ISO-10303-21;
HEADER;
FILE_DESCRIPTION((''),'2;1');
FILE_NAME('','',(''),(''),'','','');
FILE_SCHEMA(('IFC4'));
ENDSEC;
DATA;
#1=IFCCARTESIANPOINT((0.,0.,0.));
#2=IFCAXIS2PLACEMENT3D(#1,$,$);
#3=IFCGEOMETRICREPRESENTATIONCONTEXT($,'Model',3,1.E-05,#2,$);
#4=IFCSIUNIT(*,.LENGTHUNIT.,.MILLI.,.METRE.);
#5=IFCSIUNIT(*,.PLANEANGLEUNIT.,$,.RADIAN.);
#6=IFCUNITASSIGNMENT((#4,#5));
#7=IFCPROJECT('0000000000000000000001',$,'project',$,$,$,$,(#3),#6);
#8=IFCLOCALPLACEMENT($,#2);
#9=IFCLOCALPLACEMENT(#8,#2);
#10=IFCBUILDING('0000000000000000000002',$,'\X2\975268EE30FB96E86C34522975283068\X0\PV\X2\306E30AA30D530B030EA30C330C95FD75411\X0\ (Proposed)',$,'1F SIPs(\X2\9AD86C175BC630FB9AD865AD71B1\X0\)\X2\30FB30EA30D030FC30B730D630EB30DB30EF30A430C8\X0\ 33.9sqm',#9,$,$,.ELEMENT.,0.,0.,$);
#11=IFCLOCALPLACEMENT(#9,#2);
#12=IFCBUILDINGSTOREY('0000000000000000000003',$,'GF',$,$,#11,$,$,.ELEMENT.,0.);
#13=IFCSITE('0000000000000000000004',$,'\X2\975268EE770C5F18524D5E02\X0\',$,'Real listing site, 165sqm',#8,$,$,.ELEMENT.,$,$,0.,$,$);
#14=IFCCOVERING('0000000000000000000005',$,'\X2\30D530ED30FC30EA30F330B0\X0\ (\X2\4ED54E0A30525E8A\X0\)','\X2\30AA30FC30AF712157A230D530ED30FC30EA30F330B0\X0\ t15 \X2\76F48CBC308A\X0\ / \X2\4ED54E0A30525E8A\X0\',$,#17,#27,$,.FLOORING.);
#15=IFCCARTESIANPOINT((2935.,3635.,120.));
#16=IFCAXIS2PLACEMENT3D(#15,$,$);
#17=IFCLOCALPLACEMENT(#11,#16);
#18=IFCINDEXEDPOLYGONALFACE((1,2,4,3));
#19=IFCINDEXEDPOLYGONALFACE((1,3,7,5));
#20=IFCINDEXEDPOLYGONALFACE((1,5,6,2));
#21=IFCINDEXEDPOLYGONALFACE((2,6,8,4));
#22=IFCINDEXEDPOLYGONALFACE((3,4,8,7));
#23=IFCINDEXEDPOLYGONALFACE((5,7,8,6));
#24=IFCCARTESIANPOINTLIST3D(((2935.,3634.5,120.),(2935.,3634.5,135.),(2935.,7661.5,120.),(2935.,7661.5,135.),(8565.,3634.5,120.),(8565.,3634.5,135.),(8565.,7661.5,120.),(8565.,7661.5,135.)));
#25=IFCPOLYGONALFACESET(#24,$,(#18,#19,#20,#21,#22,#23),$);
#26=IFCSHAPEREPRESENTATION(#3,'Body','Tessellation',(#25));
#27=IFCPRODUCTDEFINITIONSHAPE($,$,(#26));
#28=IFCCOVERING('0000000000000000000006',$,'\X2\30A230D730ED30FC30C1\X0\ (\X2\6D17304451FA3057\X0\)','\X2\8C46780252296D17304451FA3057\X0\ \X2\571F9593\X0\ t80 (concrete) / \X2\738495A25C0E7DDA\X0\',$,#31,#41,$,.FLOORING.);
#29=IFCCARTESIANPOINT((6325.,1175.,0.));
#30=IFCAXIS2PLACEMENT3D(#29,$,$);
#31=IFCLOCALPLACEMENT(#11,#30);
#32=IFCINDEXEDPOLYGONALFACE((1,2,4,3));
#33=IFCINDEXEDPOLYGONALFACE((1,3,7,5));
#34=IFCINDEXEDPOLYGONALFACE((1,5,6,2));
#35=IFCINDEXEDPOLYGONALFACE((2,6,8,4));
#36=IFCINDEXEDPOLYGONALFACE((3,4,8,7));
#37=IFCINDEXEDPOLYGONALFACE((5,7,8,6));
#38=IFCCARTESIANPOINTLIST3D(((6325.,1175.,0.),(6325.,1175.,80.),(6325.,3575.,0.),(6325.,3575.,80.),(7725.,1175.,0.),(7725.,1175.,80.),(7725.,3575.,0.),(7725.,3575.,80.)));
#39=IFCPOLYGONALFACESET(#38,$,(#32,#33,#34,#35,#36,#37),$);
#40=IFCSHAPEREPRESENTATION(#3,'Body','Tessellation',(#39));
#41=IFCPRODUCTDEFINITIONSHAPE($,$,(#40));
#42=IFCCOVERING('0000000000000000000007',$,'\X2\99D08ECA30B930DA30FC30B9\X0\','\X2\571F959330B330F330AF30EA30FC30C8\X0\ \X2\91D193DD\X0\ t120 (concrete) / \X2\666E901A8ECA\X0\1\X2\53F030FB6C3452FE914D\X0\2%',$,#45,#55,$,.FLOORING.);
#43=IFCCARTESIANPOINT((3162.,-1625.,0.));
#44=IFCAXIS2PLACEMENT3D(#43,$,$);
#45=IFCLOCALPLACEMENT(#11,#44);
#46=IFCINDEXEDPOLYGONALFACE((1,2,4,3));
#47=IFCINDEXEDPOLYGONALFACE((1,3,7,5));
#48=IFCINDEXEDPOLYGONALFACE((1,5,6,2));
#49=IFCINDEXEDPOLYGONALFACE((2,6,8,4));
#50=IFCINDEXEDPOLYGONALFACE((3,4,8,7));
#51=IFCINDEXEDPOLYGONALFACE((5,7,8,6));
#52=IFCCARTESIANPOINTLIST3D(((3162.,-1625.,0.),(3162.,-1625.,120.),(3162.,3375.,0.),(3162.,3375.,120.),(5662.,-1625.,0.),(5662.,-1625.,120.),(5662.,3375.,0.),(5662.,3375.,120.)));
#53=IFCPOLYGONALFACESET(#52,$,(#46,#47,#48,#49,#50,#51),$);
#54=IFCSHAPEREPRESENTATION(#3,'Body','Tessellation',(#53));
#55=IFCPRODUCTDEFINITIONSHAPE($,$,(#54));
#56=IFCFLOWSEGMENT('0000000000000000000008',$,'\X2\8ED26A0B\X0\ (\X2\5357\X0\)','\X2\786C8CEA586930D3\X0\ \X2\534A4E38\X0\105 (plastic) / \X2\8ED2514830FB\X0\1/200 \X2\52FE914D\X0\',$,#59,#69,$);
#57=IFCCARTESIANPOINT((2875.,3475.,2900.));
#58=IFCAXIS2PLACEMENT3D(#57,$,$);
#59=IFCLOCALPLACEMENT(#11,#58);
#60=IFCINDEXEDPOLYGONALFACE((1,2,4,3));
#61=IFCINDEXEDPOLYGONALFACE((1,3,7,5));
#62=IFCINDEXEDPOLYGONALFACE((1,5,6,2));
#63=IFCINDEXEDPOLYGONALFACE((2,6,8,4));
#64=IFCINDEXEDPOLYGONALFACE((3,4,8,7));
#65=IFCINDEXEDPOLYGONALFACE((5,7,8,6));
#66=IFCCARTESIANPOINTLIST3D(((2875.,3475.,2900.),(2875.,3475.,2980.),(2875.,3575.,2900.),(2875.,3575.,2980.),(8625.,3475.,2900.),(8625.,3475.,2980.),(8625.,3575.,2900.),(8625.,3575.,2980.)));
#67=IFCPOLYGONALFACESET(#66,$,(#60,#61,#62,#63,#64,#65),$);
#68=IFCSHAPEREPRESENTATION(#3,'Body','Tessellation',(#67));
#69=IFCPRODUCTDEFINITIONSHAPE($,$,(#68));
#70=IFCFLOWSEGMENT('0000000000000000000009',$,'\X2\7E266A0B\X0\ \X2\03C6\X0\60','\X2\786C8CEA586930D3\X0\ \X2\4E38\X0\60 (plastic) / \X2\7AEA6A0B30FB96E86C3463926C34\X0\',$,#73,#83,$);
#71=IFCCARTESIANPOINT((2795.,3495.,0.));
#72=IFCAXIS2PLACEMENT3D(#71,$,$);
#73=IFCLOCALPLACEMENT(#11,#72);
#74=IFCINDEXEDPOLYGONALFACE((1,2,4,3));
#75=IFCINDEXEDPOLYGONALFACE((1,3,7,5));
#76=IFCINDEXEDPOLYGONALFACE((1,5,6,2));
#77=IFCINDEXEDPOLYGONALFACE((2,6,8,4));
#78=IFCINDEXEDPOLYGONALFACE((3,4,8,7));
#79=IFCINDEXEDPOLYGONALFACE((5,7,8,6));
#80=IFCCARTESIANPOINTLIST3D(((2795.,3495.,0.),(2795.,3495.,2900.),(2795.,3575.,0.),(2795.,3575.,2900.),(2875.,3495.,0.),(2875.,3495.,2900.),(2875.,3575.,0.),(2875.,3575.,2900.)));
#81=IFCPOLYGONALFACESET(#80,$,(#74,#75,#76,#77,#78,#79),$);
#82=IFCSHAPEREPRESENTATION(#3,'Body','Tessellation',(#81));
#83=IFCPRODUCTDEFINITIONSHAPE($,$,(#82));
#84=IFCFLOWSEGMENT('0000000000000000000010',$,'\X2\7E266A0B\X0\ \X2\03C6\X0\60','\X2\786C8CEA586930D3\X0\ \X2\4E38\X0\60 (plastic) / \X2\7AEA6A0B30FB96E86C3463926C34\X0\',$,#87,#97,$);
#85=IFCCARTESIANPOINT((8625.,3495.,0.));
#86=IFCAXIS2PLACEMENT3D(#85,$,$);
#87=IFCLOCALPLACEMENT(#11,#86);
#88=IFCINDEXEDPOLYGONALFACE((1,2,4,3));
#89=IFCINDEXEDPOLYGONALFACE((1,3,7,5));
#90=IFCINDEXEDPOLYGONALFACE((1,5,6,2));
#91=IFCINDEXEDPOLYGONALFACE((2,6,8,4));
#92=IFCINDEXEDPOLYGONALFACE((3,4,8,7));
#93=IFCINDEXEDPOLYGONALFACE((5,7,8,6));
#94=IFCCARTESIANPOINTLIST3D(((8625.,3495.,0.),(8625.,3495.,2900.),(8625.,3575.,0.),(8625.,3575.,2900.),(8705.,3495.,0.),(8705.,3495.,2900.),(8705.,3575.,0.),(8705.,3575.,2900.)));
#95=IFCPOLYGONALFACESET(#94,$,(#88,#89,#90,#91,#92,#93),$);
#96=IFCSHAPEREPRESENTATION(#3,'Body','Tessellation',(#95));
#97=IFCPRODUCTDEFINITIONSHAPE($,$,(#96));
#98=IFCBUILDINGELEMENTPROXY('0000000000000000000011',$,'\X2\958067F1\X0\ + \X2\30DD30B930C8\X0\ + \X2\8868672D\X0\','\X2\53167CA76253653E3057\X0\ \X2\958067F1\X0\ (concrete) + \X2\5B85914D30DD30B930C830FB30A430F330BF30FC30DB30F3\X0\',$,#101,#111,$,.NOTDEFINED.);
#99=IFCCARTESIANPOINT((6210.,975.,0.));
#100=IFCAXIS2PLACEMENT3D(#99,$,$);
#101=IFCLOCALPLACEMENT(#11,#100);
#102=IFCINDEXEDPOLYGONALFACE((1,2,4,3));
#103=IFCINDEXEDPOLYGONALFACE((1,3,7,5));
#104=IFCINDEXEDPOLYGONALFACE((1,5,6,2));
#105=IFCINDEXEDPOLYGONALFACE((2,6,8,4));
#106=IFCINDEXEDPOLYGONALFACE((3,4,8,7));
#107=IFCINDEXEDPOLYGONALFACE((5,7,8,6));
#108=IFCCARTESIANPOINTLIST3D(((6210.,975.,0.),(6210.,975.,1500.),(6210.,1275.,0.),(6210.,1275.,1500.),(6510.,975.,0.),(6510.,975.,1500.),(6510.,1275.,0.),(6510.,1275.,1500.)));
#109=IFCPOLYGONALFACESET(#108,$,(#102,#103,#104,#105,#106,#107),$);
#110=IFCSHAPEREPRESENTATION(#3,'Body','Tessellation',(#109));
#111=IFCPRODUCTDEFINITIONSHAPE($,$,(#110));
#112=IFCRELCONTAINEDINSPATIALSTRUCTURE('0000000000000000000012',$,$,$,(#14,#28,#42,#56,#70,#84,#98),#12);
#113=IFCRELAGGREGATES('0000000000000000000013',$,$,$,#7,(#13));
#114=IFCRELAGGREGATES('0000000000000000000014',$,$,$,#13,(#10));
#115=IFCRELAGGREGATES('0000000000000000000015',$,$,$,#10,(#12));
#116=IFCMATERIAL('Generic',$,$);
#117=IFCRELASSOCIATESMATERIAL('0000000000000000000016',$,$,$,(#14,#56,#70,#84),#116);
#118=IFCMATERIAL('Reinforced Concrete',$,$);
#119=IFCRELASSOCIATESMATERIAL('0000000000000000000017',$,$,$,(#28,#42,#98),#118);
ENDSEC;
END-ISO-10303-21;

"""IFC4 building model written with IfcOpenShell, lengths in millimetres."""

from ifc_helpers import new_model, si_unit, frame, frame_2d, origin, place, context, project, spatial, rectangle, extrude, material, element, save


model = new_model("IFC4")

# Units and contexts
model_context = context("Model", 3, precision=1e-05, world=origin())
ifc_project = project(units=[si_unit("LENGTHUNIT", "METRE", prefix="MILLI"), si_unit("PLANEANGLEUNIT", "RADIAN")], contexts=[model_context])

# Site, building, storey
site_placement = place(None, origin())
site = spatial("IfcSite", under=ifc_project, at=site_placement, Name="青森県弘前市", ObjectType="Real listing site, 165sqm", CompositionType="ELEMENT", RefElevation=0.0)
building_placement = place(site_placement, origin())
building = spatial("IfcBuilding", under=site, at=building_placement, Name="青森・雨水利用とPVのオフグリッド志向 (Proposed)", ObjectType="1F SIPs(高気密・高断熱)・リバーシブルホワイト 33.9sqm", CompositionType="ELEMENT", ElevationOfRefHeight=0.0, ElevationOfTerrain=0.0)
storey_placement = place(building_placement, origin())
storey = spatial("IfcBuildingStorey", under=building, at=storey_placement, Name="GF", CompositionType="ELEMENT", Elevation=0.0)

# Shared definitions
ifc_material_1 = material(Name="Reinforced Concrete")

# Coverings
ifc_material_2 = material(Name="Generic")
covering_1_placement = place(storey_placement, frame((2935.0, 3635.0, 120.0)))
element("IfcCovering", 1, at=covering_1_placement, inside=storey, material=ifc_material_2, Name="フローリング (仕上げ床)", Description="オーク無垢フローリング t15 直貼り / 仕上げ床", PredefinedType="FLOORING", context=model_context, shape_type="SweptSolid", body=[
    extrude(rectangle(XDim=5630.0, YDim=4027.0, at=frame_2d((2815.0, 2013.0))), frame((2935.0, 3635.0, 120.0)), (0.0, 0.0, 1.0), 15.0),
])
covering_2_placement = place(storey_placement, frame((6325.0, 1175.0, 0.0)))
element("IfcCovering", 2, at=covering_2_placement, inside=storey, material=ifc_material_1, Name="アプローチ (洗い出し)", Description="豆砂利洗い出し 土間 t80 (concrete) / 玄関導線", PredefinedType="FLOORING", context=model_context, shape_type="SweptSolid", body=[
    extrude(rectangle(XDim=1400.0, YDim=2400.0, at=frame_2d((700.0, 1200.0))), frame((6325.0, 1175.0, 0.0)), (0.0, 0.0, 1.0), 80.0),
])
covering_3_placement = place(storey_placement, frame((3162.0, -1625.0, 0.0)))
element("IfcCovering", 3, at=covering_3_placement, inside=storey, material=ifc_material_1, Name="駐車スペース", Description="土間コンクリート 金鏝 t120 (concrete) / 普通車1台・水勾配2%", PredefinedType="FLOORING", context=model_context, shape_type="SweptSolid", body=[
    extrude(rectangle(XDim=2500.0, YDim=5000.0, at=frame_2d((1250.0, 2500.0))), frame((3162.0, -1625.0, 0.0)), (0.0, 0.0, 1.0), 120.0),
])

# Flow segments
flow_segment_1_placement = place(storey_placement, frame((2875.0, 3475.0, 2900.0)))
element("IfcFlowSegment", 4, at=flow_segment_1_placement, inside=storey, material=ifc_material_2, Name="軒樋 (南)", Description="硬質塩ビ 半丸105 (plastic) / 軒先・1/200 勾配", context=model_context, shape_type="SweptSolid", body=[
    extrude(rectangle(XDim=5750.0, YDim=100.0, at=frame_2d((2875.0, 50.0))), frame((2875.0, 3475.0, 2900.0)), (0.0, 0.0, 1.0), 80.0),
])
flow_segment_2_placement = place(storey_placement, frame((2795.0, 3495.0, 0.0)))
element("IfcFlowSegment", 5, at=flow_segment_2_placement, inside=storey, material=ifc_material_2, Name="縦樋 φ60", Description="硬質塩ビ 丸60 (plastic) / 竪樋・雨水排水", context=model_context, shape_type="SweptSolid", body=[
    extrude(rectangle(XDim=80.0, YDim=80.0, at=frame_2d((40.0, 40.0))), frame((2795.0, 3495.0, 0.0)), (0.0, 0.0, 1.0), 2900.0),
])
flow_segment_3_placement = place(storey_placement, frame((8625.0, 3495.0, 0.0)))
element("IfcFlowSegment", 6, at=flow_segment_3_placement, inside=storey, material=ifc_material_2, Name="縦樋 φ60", Description="硬質塩ビ 丸60 (plastic) / 竪樋・雨水排水", context=model_context, shape_type="SweptSolid", body=[
    extrude(rectangle(XDim=80.0, YDim=80.0, at=frame_2d((40.0, 40.0))), frame((8625.0, 3495.0, 0.0)), (0.0, 0.0, 1.0), 2900.0),
])

# Building element proxy
proxy_placement = place(storey_placement, frame((6210.0, 975.0, 0.0)))
element("IfcBuildingElementProxy", 7, at=proxy_placement, inside=storey, material=ifc_material_1, Name="門柱 + ポスト + 表札", Description="化粧打放し 門柱 (concrete) + 宅配ポスト・インターホン", PredefinedType="NOTDEFINED", context=model_context, shape_type="SweptSolid", body=[
    extrude(rectangle(XDim=300.0, YDim=300.0, at=frame_2d((150.0, 150.0))), frame((6210.0, 975.0, 0.0)), (0.0, 0.0, 1.0), 1500.0),
])

save(model, "model.ifc")
